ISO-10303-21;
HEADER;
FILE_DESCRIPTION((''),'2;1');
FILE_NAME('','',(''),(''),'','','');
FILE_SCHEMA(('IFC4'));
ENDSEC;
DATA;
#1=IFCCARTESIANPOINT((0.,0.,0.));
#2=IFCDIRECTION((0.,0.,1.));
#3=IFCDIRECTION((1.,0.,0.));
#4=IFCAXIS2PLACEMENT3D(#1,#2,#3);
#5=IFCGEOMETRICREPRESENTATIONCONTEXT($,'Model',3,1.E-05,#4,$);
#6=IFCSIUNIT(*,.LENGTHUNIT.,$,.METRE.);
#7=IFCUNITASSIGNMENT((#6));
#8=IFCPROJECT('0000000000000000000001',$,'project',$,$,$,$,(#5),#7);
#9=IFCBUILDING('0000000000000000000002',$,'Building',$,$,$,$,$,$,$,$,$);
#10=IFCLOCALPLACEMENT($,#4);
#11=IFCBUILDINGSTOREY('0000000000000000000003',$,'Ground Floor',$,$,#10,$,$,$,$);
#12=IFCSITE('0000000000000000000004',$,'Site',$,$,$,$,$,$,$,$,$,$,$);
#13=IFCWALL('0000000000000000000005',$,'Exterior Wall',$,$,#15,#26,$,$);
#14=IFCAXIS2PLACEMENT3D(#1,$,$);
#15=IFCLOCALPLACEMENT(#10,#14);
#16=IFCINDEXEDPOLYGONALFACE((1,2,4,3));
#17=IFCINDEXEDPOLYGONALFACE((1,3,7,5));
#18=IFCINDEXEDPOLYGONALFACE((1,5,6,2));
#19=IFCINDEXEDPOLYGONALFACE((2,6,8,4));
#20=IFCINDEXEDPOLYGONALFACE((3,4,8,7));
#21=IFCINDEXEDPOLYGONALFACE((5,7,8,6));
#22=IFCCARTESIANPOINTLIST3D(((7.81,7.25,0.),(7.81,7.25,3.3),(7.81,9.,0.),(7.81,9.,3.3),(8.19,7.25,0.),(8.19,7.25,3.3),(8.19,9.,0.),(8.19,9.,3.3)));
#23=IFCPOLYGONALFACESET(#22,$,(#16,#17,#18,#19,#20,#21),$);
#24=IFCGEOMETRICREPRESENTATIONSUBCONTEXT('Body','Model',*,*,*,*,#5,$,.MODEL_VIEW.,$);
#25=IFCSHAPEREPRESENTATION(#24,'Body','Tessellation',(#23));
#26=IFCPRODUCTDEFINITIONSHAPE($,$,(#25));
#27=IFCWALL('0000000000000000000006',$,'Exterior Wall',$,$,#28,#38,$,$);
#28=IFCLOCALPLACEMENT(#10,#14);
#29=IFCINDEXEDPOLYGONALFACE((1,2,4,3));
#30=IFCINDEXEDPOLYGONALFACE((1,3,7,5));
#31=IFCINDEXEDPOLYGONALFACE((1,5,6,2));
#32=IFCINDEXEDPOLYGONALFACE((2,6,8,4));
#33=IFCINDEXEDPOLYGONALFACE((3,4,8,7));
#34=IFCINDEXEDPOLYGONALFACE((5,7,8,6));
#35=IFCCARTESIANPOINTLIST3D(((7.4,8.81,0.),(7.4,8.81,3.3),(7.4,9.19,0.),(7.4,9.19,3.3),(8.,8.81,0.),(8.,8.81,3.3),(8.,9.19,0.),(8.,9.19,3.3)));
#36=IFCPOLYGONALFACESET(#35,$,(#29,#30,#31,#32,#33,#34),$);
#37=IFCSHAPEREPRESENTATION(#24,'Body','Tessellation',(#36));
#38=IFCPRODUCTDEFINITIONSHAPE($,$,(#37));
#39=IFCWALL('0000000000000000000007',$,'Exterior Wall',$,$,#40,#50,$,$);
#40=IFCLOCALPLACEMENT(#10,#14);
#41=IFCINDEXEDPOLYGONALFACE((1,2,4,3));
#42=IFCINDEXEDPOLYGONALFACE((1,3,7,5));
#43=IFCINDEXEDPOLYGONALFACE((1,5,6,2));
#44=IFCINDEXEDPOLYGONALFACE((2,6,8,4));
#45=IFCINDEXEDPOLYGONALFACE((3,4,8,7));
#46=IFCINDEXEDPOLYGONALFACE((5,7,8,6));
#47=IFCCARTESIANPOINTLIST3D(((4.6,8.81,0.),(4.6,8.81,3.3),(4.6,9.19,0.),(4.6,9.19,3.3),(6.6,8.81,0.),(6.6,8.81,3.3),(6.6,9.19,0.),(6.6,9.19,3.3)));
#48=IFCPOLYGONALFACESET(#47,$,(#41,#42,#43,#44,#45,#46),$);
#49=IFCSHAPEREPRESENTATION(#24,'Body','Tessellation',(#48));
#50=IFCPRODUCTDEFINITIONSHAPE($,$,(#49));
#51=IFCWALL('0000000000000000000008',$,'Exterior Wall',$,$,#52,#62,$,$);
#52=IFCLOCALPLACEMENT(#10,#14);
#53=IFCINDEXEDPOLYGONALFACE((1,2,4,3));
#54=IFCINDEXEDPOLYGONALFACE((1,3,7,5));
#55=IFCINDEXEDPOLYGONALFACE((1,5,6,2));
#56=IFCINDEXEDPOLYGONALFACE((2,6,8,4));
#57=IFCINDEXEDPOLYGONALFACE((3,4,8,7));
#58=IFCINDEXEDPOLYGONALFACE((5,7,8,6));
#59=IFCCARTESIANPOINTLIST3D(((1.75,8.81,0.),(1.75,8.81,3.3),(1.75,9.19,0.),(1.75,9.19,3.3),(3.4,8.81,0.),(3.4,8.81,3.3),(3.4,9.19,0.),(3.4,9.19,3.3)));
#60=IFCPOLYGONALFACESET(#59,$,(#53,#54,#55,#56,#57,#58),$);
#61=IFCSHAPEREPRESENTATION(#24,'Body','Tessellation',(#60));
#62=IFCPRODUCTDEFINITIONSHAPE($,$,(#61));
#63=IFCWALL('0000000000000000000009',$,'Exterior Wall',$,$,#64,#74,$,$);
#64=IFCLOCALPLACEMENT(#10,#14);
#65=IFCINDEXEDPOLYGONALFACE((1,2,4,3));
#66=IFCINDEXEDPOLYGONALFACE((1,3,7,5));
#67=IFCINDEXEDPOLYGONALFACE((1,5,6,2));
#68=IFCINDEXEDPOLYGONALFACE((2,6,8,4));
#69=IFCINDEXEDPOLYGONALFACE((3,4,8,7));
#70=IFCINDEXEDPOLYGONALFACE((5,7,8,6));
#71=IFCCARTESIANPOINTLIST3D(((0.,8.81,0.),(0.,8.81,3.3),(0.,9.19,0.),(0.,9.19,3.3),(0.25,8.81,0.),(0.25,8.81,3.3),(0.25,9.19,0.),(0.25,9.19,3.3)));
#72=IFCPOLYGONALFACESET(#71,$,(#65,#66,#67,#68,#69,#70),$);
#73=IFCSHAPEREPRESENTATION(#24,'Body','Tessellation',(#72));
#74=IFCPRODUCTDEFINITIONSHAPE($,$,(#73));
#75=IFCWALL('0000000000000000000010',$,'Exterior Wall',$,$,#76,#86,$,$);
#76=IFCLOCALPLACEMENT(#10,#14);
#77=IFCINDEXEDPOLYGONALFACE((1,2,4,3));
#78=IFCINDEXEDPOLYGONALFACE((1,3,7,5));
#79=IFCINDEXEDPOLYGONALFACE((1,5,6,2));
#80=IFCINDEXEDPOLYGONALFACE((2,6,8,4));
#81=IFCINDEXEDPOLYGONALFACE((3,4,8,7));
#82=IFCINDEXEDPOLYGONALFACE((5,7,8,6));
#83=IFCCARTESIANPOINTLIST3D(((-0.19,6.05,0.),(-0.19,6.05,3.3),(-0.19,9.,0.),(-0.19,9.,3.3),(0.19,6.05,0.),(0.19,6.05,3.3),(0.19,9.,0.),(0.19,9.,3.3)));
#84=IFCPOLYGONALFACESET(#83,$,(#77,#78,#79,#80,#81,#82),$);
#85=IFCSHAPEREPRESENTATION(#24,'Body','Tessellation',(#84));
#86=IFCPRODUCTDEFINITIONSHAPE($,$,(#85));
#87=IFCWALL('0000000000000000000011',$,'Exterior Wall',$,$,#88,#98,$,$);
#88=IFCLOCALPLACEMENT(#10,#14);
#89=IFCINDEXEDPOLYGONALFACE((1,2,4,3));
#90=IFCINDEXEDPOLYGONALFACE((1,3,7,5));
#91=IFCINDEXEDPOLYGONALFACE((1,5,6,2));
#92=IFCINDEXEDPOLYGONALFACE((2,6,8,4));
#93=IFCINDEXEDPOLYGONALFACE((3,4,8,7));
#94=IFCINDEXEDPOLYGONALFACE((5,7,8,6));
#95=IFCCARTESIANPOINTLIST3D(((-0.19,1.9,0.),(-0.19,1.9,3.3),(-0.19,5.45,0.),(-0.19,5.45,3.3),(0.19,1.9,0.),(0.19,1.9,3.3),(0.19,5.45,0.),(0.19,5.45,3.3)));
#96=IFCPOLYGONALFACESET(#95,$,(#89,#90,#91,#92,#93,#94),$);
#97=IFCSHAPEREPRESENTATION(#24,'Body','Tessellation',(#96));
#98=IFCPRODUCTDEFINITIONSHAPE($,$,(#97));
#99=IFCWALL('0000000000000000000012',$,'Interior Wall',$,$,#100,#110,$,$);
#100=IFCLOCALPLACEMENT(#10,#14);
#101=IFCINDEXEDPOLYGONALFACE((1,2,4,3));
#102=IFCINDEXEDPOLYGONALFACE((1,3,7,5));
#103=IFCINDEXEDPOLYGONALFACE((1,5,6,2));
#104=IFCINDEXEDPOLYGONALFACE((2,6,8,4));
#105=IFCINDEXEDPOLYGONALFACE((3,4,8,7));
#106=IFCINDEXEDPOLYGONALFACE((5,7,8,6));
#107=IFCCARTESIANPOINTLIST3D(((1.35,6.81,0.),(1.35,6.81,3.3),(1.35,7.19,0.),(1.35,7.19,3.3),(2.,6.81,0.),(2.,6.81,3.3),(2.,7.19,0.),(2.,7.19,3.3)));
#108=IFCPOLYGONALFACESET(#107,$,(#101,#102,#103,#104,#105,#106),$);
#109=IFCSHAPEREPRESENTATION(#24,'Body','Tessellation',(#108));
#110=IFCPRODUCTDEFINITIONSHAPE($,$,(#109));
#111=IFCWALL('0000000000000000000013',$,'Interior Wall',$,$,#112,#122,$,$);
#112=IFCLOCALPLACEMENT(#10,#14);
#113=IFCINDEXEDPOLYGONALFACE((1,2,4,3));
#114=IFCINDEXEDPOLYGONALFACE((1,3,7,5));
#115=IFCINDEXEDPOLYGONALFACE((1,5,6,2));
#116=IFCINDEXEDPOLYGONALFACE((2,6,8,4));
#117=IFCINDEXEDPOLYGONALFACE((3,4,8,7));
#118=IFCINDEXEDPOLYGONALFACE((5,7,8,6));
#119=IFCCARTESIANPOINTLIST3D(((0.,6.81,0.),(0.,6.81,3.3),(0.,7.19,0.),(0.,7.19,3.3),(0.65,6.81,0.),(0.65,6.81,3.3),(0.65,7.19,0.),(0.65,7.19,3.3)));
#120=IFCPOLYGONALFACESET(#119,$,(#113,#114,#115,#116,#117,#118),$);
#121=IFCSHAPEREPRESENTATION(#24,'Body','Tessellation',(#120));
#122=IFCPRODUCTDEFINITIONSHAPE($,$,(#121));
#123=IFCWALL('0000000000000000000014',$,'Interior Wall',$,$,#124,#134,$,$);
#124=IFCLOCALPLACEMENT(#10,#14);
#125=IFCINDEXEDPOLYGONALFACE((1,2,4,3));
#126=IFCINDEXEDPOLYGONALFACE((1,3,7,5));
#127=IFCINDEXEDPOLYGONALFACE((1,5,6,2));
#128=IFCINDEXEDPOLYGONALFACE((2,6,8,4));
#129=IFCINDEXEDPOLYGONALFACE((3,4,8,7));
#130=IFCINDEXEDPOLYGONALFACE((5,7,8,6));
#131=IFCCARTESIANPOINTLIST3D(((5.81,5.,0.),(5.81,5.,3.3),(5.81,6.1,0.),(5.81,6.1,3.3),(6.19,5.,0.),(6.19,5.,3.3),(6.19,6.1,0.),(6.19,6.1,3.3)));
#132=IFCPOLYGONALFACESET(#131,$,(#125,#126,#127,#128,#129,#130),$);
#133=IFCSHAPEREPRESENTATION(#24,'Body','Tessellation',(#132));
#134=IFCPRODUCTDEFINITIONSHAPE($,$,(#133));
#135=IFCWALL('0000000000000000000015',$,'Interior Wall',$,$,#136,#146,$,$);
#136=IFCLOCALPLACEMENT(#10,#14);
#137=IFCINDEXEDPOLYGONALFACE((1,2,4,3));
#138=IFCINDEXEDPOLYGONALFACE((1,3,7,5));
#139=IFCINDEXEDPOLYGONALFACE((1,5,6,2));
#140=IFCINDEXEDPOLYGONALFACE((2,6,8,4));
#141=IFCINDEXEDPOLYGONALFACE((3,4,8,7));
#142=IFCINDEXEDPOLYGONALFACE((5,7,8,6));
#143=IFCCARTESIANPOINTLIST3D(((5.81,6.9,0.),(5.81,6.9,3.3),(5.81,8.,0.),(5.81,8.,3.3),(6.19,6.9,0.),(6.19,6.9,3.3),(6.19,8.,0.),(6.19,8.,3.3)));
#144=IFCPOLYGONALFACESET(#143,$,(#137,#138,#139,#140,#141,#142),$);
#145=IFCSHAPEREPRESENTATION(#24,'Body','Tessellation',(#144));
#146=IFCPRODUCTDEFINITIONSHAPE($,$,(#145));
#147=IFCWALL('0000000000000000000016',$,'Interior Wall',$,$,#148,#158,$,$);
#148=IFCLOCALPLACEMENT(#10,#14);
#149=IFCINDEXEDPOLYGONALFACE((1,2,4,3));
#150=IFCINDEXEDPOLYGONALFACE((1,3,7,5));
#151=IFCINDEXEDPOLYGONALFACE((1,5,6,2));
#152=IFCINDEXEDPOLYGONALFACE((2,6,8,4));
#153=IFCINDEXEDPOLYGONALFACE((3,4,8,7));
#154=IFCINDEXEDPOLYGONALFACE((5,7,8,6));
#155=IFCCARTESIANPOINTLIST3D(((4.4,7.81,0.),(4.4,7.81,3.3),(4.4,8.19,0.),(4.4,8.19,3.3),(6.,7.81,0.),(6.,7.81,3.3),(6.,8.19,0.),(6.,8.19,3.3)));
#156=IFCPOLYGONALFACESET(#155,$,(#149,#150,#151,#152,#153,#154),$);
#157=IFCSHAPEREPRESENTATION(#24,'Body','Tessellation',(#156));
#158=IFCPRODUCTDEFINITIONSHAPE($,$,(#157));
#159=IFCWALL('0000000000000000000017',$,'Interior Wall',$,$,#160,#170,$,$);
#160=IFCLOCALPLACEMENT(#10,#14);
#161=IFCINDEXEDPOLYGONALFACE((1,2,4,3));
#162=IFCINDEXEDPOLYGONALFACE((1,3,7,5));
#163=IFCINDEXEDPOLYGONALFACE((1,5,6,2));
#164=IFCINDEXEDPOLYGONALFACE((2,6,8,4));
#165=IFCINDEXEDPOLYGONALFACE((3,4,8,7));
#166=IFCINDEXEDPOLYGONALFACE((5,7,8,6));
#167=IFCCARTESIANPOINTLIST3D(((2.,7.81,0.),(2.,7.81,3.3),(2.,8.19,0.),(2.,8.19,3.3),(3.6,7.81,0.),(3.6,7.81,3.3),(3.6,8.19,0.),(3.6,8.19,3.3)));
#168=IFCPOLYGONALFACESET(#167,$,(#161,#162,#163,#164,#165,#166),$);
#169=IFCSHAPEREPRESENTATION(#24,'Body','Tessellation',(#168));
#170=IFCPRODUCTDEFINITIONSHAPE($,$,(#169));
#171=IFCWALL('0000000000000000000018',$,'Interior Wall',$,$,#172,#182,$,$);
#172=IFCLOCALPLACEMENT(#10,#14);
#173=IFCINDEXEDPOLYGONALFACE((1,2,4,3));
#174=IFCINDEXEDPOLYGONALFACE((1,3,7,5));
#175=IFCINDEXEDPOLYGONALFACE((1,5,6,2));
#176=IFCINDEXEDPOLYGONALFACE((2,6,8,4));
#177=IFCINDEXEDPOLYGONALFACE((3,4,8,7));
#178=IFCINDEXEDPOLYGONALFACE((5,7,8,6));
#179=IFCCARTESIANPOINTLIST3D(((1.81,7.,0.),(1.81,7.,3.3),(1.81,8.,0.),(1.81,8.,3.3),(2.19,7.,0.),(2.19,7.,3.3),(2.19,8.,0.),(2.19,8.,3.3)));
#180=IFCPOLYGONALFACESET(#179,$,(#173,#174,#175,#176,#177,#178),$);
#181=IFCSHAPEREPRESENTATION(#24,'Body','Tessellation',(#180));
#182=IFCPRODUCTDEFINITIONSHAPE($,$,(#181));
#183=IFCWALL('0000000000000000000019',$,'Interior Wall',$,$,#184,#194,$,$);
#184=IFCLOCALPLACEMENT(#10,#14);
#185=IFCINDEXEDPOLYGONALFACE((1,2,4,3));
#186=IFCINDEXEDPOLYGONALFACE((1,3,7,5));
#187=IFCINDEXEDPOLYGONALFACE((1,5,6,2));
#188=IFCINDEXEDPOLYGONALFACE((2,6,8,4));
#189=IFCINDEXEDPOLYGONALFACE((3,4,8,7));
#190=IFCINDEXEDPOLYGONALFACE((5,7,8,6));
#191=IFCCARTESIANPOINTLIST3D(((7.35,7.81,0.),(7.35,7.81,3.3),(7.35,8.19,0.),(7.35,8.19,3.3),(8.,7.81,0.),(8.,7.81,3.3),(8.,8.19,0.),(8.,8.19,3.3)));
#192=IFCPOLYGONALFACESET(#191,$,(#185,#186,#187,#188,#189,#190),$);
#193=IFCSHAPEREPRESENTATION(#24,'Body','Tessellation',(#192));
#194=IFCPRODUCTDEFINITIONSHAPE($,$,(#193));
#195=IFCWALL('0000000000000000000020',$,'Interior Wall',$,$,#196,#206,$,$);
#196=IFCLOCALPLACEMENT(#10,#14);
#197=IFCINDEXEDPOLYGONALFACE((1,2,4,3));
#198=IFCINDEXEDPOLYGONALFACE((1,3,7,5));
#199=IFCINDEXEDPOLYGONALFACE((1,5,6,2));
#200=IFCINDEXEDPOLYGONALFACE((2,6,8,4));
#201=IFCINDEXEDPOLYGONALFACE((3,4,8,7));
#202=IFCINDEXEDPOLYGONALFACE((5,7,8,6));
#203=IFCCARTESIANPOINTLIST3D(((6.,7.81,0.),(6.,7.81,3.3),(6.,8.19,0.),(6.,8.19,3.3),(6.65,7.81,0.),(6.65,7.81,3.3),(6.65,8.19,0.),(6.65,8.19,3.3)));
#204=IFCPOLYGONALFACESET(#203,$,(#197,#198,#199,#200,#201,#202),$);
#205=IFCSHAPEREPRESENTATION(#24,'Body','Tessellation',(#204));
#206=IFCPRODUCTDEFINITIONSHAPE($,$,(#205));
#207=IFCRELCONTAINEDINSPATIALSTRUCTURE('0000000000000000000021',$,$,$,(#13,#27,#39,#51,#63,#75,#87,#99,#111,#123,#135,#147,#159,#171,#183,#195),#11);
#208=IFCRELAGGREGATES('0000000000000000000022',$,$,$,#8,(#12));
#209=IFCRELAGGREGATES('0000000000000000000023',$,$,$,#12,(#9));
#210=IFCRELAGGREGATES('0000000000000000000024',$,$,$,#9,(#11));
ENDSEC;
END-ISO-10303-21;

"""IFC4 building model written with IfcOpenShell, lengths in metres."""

from ifc_helpers import new_model, si_unit, frame, origin_with_axes, place, context, subcontext, project, spatial, indexed_curve, outline, extrude, element, save


model = new_model("IFC4")

# Units and contexts
model_context = context("Model", 3, precision=1e-05, world=origin_with_axes())
body_context = subcontext(model_context, "Body", "Model", "MODEL_VIEW")
ifc_project = project(units=[si_unit("LENGTHUNIT", "METRE")], contexts=[model_context])

# Site, building, storey
site = spatial("IfcSite", under=ifc_project, Name="Site")
building = spatial("IfcBuilding", under=site, Name="Building")
storey_placement = place(None, origin_with_axes())
storey = spatial("IfcBuildingStorey", under=building, at=storey_placement, Name="Ground Floor")

# Walls
wall_1_placement = place(storey_placement, frame((8.0, 7.25, 0.0), z_axis=(0.0, 0.0, 1.0), x_axis=(0.0, 1.0, 0.0)))
element("IfcWall", 1, at=wall_1_placement, inside=storey, Name="Exterior Wall", context=body_context, shape_type="SweptSolid", body=[
    extrude(outline(indexed_curve([(0.0, 0.0), (0.0, 0.38), (1.75, 0.38), (1.75, 0.0), (0.0, 0.0)], self_intersect=False)), frame((0.0, -0.19, 0.0), z_axis=(0.0, 0.0, 1.0), x_axis=(1.0, 0.0, 0.0)), (0.0, 0.0, 1.0), 3.3),
])
wall_2_placement = place(storey_placement, frame((8.0, 9.0, 0.0), z_axis=(0.0, 0.0, 1.0), x_axis=(-1.0, 0.0, 0.0)))
element("IfcWall", 2, at=wall_2_placement, inside=storey, Name="Exterior Wall", context=body_context, shape_type="SweptSolid", body=[
    extrude(outline(indexed_curve([(0.0, 0.0), (0.0, 0.38), (0.6, 0.38), (0.6, 0.0), (0.0, 0.0)], self_intersect=False)), frame((0.0, -0.19, 0.0), z_axis=(0.0, 0.0, 1.0), x_axis=(1.0, 0.0, 0.0)), (0.0, 0.0, 1.0), 3.3),
])
wall_3_placement = place(storey_placement, frame((6.6, 9.0, 0.0), z_axis=(0.0, 0.0, 1.0), x_axis=(-1.0, 0.0, 0.0)))
element("IfcWall", 3, at=wall_3_placement, inside=storey, Name="Exterior Wall", context=body_context, shape_type="SweptSolid", body=[
    extrude(outline(indexed_curve([(0.0, 0.0), (0.0, 0.38), (2.0, 0.38), (2.0, 0.0), (0.0, 0.0)], self_intersect=False)), frame((0.0, -0.19, 0.0), z_axis=(0.0, 0.0, 1.0), x_axis=(1.0, 0.0, 0.0)), (0.0, 0.0, 1.0), 3.3),
])
wall_4_placement = place(storey_placement, frame((3.4, 9.0, 0.0), z_axis=(0.0, 0.0, 1.0), x_axis=(-1.0, 0.0, 0.0)))
element("IfcWall", 4, at=wall_4_placement, inside=storey, Name="Exterior Wall", context=body_context, shape_type="SweptSolid", body=[
    extrude(outline(indexed_curve([(0.0, 0.0), (0.0, 0.38), (1.65, 0.38), (1.65, 0.0), (0.0, 0.0)], self_intersect=False)), frame((0.0, -0.19, 0.0), z_axis=(0.0, 0.0, 1.0), x_axis=(1.0, 0.0, 0.0)), (0.0, 0.0, 1.0), 3.3),
])
wall_5_placement = place(storey_placement, frame((0.25, 9.0, 0.0), z_axis=(0.0, 0.0, 1.0), x_axis=(-1.0, 0.0, 0.0)))
element("IfcWall", 5, at=wall_5_placement, inside=storey, Name="Exterior Wall", context=body_context, shape_type="SweptSolid", body=[
    extrude(outline(indexed_curve([(0.0, 0.0), (0.0, 0.38), (0.25, 0.38), (0.25, 0.0), (0.0, 0.0)], self_intersect=False)), frame((0.0, -0.19, 0.0), z_axis=(0.0, 0.0, 1.0), x_axis=(1.0, 0.0, 0.0)), (0.0, 0.0, 1.0), 3.3),
])
wall_6_placement = place(storey_placement, frame((0.0, 9.0, 0.0), z_axis=(0.0, 0.0, 1.0), x_axis=(0.0, -1.0, 0.0)))
element("IfcWall", 6, at=wall_6_placement, inside=storey, Name="Exterior Wall", context=body_context, shape_type="SweptSolid", body=[
    extrude(outline(indexed_curve([(0.0, 0.0), (0.0, 0.38), (2.95, 0.38), (2.95, 0.0), (0.0, 0.0)], self_intersect=False)), frame((0.0, -0.19, 0.0), z_axis=(0.0, 0.0, 1.0), x_axis=(1.0, 0.0, 0.0)), (0.0, 0.0, 1.0), 3.3),
])
wall_7_placement = place(storey_placement, frame((0.0, 5.45, 0.0), z_axis=(0.0, 0.0, 1.0), x_axis=(0.0, -1.0, 0.0)))
element("IfcWall", 7, at=wall_7_placement, inside=storey, Name="Exterior Wall", context=body_context, shape_type="SweptSolid", body=[
    extrude(outline(indexed_curve([(0.0, 0.0), (0.0, 0.38), (3.55, 0.38), (3.55, 0.0), (0.0, 0.0)], self_intersect=False)), frame((0.0, -0.19, 0.0), z_axis=(0.0, 0.0, 1.0), x_axis=(1.0, 0.0, 0.0)), (0.0, 0.0, 1.0), 3.3),
])
for number, where, z_axis, x_axis, name in (
    (8, (2.0, 7.0, 0.0), (0.0, 0.0, 1.0), (-1.0, 0.0, 0.0), "Interior Wall"),
    (9, (0.65, 7.0, 0.0), (0.0, 0.0, 1.0), (-1.0, 0.0, 0.0), "Interior Wall"),
):
    element("IfcWall", number, at=place(storey_placement, frame(where, z_axis=z_axis, x_axis=x_axis)), inside=storey, Name=name, context=body_context, shape_type="SweptSolid", body=[
        extrude(outline(indexed_curve([(0.0, 0.0), (0.0, 0.38), (0.65, 0.38), (0.65, 0.0), (0.0, 0.0)], self_intersect=False)), frame((0.0, -0.19, 0.0), z_axis=(0.0, 0.0, 1.0), x_axis=(1.0, 0.0, 0.0)), (0.0, 0.0, 1.0), 3.3),
    ])
for number, where, z_axis, x_axis, name in (
    (10, (6.0, 5.0, 0.0), (0.0, 0.0, 1.0), (0.0, 1.0, 0.0), "Interior Wall"),
    (11, (6.0, 6.9, 0.0), (0.0, 0.0, 1.0), (0.0, 1.0, 0.0), "Interior Wall"),
):
    element("IfcWall", number, at=place(storey_placement, frame(where, z_axis=z_axis, x_axis=x_axis)), inside=storey, Name=name, context=body_context, shape_type="SweptSolid", body=[
        extrude(outline(indexed_curve([(0.0, 0.0), (0.0, 0.38), (1.1, 0.38), (1.1, 0.0), (0.0, 0.0)], self_intersect=False)), frame((0.0, -0.19, 0.0), z_axis=(0.0, 0.0, 1.0), x_axis=(1.0, 0.0, 0.0)), (0.0, 0.0, 1.0), 3.3),
    ])
wall_8_placement = place(storey_placement, frame((6.0, 8.0, 0.0), z_axis=(0.0, 0.0, 1.0), x_axis=(-1.0, 0.0, 0.0)))
element("IfcWall", 12, at=wall_8_placement, inside=storey, Name="Interior Wall", context=body_context, shape_type="SweptSolid", body=[
    extrude(outline(indexed_curve([(0.0, 0.0), (0.0, 0.38), (1.6, 0.38), (1.6, 0.0), (0.0, 0.0)], self_intersect=False)), frame((0.0, -0.19, 0.0), z_axis=(0.0, 0.0, 1.0), x_axis=(1.0, 0.0, 0.0)), (0.0, 0.0, 1.0), 3.3),
])
wall_9_placement = place(storey_placement, frame((3.6, 8.0, 0.0), z_axis=(0.0, 0.0, 1.0), x_axis=(-1.0, 0.0, 0.0)))
element("IfcWall", 13, at=wall_9_placement, inside=storey, Name="Interior Wall", context=body_context, shape_type="SweptSolid", body=[
    extrude(outline(indexed_curve([(0.0, 0.0), (0.0, 0.38), (1.6, 0.38), (1.6, 0.0), (0.0, 0.0)], self_intersect=False)), frame((0.0, -0.19, 0.0), z_axis=(0.0, 0.0, 1.0), x_axis=(1.0, 0.0, 0.0)), (0.0, 0.0, 1.0), 3.3),
])
wall_10_placement = place(storey_placement, frame((2.0, 8.0, 0.0), z_axis=(0.0, 0.0, 1.0), x_axis=(0.0, -1.0, 0.0)))
element("IfcWall", 14, at=wall_10_placement, inside=storey, Name="Interior Wall", context=body_context, shape_type="SweptSolid", body=[
    extrude(outline(indexed_curve([(0.0, 0.0), (0.0, 0.38), (1.0, 0.38), (1.0, 0.0), (0.0, 0.0)], self_intersect=False)), frame((0.0, -0.19, 0.0), z_axis=(0.0, 0.0, 1.0), x_axis=(1.0, 0.0, 0.0)), (0.0, 0.0, 1.0), 3.3),
])
for number, where, z_axis, x_axis, name in (
    (15, (8.0, 8.0, 0.0), (0.0, 0.0, 1.0), (-1.0, 0.0, 0.0), "Interior Wall"),
    (16, (6.65, 8.0, 0.0), (0.0, 0.0, 1.0), (-1.0, 0.0, 0.0), "Interior Wall"),
):
    element("IfcWall", number, at=place(storey_placement, frame(where, z_axis=z_axis, x_axis=x_axis)), inside=storey, Name=name, context=body_context, shape_type="SweptSolid", body=[
        extrude(outline(indexed_curve([(0.0, 0.0), (0.0, 0.38), (0.65, 0.38), (0.65, 0.0), (0.0, 0.0)], self_intersect=False)), frame((0.0, -0.19, 0.0), z_axis=(0.0, 0.0, 1.0), x_axis=(1.0, 0.0, 0.0)), (0.0, 0.0, 1.0), 3.3),
    ])

save(model, "model.ifc")
